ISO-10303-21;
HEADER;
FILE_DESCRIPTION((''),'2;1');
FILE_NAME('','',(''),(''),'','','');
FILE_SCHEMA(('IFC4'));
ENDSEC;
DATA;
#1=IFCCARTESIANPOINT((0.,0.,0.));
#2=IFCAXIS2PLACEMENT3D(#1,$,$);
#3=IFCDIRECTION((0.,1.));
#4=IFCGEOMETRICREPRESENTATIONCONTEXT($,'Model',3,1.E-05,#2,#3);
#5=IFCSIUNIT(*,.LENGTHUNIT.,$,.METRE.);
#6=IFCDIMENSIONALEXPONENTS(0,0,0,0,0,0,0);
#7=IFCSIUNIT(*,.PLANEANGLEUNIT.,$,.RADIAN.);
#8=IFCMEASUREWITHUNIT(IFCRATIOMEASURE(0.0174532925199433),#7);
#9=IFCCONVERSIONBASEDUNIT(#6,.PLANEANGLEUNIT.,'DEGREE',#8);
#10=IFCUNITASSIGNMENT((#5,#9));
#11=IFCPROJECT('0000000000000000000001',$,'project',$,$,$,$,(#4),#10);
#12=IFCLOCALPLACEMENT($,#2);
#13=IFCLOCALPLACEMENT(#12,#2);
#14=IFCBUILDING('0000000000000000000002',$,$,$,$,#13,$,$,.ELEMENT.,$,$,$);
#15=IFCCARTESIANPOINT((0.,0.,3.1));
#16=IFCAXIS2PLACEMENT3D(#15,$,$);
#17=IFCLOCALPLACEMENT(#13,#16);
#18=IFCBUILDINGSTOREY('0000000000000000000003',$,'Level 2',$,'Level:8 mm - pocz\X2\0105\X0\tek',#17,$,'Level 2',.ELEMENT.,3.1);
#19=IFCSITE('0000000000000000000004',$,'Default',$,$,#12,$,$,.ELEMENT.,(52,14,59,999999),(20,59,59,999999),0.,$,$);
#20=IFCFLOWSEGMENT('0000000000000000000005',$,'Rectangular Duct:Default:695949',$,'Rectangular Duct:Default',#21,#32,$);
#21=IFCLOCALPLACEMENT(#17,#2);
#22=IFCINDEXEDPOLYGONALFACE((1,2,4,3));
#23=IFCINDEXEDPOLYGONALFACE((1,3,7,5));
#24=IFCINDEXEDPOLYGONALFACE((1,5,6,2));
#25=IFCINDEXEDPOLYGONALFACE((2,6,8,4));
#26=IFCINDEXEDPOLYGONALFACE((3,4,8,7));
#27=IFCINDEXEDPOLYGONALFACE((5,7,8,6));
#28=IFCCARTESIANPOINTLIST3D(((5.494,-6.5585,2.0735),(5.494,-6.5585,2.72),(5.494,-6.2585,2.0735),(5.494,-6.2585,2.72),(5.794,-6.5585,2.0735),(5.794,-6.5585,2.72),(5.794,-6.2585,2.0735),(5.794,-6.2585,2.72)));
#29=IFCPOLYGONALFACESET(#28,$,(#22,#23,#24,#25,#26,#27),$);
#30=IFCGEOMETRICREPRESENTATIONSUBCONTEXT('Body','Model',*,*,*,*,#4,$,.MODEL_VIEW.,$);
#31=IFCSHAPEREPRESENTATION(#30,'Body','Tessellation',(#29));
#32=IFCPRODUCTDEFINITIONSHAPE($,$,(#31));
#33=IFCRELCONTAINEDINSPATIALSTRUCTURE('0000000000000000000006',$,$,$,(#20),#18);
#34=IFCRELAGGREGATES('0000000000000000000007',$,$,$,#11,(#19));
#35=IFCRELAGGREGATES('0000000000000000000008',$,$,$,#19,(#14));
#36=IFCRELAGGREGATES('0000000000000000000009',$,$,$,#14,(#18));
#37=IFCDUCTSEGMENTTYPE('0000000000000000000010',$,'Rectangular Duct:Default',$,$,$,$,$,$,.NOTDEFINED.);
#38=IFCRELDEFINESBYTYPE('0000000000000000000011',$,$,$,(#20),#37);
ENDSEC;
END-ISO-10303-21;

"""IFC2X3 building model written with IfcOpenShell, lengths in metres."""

from ifc_helpers import new_model, entity, si_unit, converted_unit, direction, frame, frame_2d, origin, place, context, subcontext, project, spatial, rectangle, extrude, type_object, element, save


model = new_model("IFC2X3")

# Units and contexts
model_context = context("Model", 3, precision=1e-05, world=origin(), true_north=direction((0.0, 1.0)))
body_context = subcontext(model_context, "Body", "Model", "MODEL_VIEW")
ifc_project = project(units=[si_unit("LENGTHUNIT", "METRE"), converted_unit("PLANEANGLEUNIT", "DEGREE", entity("IfcRatioMeasure", 0.0174532925199433), si_unit("PLANEANGLEUNIT", "RADIAN"), dimensions=[0, 0, 0, 0, 0, 0, 0])], contexts=[model_context])

# Site, building, storey
site_placement = place(None, origin())
site = spatial("IfcSite", under=ifc_project, at=site_placement, Name="Default", CompositionType="ELEMENT", RefLatitude=(52, 14, 59, 999999), RefLongitude=(20, 59, 59, 999999), RefElevation=0.0)
building_placement = place(site_placement, origin())
building = spatial("IfcBuilding", under=site, at=building_placement, CompositionType="ELEMENT")
storey_placement = place(building_placement, frame((0.0, 0.0, 3.1)))
storey = spatial("IfcBuildingStorey", under=building, at=storey_placement, Name="Level 2", ObjectType="Level:8 mm - początek", LongName="Level 2", CompositionType="ELEMENT", Elevation=3.1)

# Flow segment
duct_segment_type = type_object("IfcDuctSegmentType", Name="Rectangular Duct:Default", PredefinedType="NOTDEFINED")
flow_segment_1_placement = place(storey_placement, origin())
element("IfcFlowSegment", 1, at=flow_segment_1_placement, inside=storey, type_object=duct_segment_type, Name="Rectangular Duct:Default:695949", ObjectType="Rectangular Duct:Default", context=body_context, shape_type="SweptSolid", body=[
    extrude(rectangle(XDim=0.3, YDim=0.3, at=frame_2d((0.0, 0.0), x_axis=(1.0, 0.0))), frame((5.644, -6.4085, 2.0735), z_axis=(0.0, 0.0, 1.0), x_axis=(0.0, 1.0, 0.0)), (0.0, 0.0, 1.0), 0.6465),
])

save(model, "model.ifc")
